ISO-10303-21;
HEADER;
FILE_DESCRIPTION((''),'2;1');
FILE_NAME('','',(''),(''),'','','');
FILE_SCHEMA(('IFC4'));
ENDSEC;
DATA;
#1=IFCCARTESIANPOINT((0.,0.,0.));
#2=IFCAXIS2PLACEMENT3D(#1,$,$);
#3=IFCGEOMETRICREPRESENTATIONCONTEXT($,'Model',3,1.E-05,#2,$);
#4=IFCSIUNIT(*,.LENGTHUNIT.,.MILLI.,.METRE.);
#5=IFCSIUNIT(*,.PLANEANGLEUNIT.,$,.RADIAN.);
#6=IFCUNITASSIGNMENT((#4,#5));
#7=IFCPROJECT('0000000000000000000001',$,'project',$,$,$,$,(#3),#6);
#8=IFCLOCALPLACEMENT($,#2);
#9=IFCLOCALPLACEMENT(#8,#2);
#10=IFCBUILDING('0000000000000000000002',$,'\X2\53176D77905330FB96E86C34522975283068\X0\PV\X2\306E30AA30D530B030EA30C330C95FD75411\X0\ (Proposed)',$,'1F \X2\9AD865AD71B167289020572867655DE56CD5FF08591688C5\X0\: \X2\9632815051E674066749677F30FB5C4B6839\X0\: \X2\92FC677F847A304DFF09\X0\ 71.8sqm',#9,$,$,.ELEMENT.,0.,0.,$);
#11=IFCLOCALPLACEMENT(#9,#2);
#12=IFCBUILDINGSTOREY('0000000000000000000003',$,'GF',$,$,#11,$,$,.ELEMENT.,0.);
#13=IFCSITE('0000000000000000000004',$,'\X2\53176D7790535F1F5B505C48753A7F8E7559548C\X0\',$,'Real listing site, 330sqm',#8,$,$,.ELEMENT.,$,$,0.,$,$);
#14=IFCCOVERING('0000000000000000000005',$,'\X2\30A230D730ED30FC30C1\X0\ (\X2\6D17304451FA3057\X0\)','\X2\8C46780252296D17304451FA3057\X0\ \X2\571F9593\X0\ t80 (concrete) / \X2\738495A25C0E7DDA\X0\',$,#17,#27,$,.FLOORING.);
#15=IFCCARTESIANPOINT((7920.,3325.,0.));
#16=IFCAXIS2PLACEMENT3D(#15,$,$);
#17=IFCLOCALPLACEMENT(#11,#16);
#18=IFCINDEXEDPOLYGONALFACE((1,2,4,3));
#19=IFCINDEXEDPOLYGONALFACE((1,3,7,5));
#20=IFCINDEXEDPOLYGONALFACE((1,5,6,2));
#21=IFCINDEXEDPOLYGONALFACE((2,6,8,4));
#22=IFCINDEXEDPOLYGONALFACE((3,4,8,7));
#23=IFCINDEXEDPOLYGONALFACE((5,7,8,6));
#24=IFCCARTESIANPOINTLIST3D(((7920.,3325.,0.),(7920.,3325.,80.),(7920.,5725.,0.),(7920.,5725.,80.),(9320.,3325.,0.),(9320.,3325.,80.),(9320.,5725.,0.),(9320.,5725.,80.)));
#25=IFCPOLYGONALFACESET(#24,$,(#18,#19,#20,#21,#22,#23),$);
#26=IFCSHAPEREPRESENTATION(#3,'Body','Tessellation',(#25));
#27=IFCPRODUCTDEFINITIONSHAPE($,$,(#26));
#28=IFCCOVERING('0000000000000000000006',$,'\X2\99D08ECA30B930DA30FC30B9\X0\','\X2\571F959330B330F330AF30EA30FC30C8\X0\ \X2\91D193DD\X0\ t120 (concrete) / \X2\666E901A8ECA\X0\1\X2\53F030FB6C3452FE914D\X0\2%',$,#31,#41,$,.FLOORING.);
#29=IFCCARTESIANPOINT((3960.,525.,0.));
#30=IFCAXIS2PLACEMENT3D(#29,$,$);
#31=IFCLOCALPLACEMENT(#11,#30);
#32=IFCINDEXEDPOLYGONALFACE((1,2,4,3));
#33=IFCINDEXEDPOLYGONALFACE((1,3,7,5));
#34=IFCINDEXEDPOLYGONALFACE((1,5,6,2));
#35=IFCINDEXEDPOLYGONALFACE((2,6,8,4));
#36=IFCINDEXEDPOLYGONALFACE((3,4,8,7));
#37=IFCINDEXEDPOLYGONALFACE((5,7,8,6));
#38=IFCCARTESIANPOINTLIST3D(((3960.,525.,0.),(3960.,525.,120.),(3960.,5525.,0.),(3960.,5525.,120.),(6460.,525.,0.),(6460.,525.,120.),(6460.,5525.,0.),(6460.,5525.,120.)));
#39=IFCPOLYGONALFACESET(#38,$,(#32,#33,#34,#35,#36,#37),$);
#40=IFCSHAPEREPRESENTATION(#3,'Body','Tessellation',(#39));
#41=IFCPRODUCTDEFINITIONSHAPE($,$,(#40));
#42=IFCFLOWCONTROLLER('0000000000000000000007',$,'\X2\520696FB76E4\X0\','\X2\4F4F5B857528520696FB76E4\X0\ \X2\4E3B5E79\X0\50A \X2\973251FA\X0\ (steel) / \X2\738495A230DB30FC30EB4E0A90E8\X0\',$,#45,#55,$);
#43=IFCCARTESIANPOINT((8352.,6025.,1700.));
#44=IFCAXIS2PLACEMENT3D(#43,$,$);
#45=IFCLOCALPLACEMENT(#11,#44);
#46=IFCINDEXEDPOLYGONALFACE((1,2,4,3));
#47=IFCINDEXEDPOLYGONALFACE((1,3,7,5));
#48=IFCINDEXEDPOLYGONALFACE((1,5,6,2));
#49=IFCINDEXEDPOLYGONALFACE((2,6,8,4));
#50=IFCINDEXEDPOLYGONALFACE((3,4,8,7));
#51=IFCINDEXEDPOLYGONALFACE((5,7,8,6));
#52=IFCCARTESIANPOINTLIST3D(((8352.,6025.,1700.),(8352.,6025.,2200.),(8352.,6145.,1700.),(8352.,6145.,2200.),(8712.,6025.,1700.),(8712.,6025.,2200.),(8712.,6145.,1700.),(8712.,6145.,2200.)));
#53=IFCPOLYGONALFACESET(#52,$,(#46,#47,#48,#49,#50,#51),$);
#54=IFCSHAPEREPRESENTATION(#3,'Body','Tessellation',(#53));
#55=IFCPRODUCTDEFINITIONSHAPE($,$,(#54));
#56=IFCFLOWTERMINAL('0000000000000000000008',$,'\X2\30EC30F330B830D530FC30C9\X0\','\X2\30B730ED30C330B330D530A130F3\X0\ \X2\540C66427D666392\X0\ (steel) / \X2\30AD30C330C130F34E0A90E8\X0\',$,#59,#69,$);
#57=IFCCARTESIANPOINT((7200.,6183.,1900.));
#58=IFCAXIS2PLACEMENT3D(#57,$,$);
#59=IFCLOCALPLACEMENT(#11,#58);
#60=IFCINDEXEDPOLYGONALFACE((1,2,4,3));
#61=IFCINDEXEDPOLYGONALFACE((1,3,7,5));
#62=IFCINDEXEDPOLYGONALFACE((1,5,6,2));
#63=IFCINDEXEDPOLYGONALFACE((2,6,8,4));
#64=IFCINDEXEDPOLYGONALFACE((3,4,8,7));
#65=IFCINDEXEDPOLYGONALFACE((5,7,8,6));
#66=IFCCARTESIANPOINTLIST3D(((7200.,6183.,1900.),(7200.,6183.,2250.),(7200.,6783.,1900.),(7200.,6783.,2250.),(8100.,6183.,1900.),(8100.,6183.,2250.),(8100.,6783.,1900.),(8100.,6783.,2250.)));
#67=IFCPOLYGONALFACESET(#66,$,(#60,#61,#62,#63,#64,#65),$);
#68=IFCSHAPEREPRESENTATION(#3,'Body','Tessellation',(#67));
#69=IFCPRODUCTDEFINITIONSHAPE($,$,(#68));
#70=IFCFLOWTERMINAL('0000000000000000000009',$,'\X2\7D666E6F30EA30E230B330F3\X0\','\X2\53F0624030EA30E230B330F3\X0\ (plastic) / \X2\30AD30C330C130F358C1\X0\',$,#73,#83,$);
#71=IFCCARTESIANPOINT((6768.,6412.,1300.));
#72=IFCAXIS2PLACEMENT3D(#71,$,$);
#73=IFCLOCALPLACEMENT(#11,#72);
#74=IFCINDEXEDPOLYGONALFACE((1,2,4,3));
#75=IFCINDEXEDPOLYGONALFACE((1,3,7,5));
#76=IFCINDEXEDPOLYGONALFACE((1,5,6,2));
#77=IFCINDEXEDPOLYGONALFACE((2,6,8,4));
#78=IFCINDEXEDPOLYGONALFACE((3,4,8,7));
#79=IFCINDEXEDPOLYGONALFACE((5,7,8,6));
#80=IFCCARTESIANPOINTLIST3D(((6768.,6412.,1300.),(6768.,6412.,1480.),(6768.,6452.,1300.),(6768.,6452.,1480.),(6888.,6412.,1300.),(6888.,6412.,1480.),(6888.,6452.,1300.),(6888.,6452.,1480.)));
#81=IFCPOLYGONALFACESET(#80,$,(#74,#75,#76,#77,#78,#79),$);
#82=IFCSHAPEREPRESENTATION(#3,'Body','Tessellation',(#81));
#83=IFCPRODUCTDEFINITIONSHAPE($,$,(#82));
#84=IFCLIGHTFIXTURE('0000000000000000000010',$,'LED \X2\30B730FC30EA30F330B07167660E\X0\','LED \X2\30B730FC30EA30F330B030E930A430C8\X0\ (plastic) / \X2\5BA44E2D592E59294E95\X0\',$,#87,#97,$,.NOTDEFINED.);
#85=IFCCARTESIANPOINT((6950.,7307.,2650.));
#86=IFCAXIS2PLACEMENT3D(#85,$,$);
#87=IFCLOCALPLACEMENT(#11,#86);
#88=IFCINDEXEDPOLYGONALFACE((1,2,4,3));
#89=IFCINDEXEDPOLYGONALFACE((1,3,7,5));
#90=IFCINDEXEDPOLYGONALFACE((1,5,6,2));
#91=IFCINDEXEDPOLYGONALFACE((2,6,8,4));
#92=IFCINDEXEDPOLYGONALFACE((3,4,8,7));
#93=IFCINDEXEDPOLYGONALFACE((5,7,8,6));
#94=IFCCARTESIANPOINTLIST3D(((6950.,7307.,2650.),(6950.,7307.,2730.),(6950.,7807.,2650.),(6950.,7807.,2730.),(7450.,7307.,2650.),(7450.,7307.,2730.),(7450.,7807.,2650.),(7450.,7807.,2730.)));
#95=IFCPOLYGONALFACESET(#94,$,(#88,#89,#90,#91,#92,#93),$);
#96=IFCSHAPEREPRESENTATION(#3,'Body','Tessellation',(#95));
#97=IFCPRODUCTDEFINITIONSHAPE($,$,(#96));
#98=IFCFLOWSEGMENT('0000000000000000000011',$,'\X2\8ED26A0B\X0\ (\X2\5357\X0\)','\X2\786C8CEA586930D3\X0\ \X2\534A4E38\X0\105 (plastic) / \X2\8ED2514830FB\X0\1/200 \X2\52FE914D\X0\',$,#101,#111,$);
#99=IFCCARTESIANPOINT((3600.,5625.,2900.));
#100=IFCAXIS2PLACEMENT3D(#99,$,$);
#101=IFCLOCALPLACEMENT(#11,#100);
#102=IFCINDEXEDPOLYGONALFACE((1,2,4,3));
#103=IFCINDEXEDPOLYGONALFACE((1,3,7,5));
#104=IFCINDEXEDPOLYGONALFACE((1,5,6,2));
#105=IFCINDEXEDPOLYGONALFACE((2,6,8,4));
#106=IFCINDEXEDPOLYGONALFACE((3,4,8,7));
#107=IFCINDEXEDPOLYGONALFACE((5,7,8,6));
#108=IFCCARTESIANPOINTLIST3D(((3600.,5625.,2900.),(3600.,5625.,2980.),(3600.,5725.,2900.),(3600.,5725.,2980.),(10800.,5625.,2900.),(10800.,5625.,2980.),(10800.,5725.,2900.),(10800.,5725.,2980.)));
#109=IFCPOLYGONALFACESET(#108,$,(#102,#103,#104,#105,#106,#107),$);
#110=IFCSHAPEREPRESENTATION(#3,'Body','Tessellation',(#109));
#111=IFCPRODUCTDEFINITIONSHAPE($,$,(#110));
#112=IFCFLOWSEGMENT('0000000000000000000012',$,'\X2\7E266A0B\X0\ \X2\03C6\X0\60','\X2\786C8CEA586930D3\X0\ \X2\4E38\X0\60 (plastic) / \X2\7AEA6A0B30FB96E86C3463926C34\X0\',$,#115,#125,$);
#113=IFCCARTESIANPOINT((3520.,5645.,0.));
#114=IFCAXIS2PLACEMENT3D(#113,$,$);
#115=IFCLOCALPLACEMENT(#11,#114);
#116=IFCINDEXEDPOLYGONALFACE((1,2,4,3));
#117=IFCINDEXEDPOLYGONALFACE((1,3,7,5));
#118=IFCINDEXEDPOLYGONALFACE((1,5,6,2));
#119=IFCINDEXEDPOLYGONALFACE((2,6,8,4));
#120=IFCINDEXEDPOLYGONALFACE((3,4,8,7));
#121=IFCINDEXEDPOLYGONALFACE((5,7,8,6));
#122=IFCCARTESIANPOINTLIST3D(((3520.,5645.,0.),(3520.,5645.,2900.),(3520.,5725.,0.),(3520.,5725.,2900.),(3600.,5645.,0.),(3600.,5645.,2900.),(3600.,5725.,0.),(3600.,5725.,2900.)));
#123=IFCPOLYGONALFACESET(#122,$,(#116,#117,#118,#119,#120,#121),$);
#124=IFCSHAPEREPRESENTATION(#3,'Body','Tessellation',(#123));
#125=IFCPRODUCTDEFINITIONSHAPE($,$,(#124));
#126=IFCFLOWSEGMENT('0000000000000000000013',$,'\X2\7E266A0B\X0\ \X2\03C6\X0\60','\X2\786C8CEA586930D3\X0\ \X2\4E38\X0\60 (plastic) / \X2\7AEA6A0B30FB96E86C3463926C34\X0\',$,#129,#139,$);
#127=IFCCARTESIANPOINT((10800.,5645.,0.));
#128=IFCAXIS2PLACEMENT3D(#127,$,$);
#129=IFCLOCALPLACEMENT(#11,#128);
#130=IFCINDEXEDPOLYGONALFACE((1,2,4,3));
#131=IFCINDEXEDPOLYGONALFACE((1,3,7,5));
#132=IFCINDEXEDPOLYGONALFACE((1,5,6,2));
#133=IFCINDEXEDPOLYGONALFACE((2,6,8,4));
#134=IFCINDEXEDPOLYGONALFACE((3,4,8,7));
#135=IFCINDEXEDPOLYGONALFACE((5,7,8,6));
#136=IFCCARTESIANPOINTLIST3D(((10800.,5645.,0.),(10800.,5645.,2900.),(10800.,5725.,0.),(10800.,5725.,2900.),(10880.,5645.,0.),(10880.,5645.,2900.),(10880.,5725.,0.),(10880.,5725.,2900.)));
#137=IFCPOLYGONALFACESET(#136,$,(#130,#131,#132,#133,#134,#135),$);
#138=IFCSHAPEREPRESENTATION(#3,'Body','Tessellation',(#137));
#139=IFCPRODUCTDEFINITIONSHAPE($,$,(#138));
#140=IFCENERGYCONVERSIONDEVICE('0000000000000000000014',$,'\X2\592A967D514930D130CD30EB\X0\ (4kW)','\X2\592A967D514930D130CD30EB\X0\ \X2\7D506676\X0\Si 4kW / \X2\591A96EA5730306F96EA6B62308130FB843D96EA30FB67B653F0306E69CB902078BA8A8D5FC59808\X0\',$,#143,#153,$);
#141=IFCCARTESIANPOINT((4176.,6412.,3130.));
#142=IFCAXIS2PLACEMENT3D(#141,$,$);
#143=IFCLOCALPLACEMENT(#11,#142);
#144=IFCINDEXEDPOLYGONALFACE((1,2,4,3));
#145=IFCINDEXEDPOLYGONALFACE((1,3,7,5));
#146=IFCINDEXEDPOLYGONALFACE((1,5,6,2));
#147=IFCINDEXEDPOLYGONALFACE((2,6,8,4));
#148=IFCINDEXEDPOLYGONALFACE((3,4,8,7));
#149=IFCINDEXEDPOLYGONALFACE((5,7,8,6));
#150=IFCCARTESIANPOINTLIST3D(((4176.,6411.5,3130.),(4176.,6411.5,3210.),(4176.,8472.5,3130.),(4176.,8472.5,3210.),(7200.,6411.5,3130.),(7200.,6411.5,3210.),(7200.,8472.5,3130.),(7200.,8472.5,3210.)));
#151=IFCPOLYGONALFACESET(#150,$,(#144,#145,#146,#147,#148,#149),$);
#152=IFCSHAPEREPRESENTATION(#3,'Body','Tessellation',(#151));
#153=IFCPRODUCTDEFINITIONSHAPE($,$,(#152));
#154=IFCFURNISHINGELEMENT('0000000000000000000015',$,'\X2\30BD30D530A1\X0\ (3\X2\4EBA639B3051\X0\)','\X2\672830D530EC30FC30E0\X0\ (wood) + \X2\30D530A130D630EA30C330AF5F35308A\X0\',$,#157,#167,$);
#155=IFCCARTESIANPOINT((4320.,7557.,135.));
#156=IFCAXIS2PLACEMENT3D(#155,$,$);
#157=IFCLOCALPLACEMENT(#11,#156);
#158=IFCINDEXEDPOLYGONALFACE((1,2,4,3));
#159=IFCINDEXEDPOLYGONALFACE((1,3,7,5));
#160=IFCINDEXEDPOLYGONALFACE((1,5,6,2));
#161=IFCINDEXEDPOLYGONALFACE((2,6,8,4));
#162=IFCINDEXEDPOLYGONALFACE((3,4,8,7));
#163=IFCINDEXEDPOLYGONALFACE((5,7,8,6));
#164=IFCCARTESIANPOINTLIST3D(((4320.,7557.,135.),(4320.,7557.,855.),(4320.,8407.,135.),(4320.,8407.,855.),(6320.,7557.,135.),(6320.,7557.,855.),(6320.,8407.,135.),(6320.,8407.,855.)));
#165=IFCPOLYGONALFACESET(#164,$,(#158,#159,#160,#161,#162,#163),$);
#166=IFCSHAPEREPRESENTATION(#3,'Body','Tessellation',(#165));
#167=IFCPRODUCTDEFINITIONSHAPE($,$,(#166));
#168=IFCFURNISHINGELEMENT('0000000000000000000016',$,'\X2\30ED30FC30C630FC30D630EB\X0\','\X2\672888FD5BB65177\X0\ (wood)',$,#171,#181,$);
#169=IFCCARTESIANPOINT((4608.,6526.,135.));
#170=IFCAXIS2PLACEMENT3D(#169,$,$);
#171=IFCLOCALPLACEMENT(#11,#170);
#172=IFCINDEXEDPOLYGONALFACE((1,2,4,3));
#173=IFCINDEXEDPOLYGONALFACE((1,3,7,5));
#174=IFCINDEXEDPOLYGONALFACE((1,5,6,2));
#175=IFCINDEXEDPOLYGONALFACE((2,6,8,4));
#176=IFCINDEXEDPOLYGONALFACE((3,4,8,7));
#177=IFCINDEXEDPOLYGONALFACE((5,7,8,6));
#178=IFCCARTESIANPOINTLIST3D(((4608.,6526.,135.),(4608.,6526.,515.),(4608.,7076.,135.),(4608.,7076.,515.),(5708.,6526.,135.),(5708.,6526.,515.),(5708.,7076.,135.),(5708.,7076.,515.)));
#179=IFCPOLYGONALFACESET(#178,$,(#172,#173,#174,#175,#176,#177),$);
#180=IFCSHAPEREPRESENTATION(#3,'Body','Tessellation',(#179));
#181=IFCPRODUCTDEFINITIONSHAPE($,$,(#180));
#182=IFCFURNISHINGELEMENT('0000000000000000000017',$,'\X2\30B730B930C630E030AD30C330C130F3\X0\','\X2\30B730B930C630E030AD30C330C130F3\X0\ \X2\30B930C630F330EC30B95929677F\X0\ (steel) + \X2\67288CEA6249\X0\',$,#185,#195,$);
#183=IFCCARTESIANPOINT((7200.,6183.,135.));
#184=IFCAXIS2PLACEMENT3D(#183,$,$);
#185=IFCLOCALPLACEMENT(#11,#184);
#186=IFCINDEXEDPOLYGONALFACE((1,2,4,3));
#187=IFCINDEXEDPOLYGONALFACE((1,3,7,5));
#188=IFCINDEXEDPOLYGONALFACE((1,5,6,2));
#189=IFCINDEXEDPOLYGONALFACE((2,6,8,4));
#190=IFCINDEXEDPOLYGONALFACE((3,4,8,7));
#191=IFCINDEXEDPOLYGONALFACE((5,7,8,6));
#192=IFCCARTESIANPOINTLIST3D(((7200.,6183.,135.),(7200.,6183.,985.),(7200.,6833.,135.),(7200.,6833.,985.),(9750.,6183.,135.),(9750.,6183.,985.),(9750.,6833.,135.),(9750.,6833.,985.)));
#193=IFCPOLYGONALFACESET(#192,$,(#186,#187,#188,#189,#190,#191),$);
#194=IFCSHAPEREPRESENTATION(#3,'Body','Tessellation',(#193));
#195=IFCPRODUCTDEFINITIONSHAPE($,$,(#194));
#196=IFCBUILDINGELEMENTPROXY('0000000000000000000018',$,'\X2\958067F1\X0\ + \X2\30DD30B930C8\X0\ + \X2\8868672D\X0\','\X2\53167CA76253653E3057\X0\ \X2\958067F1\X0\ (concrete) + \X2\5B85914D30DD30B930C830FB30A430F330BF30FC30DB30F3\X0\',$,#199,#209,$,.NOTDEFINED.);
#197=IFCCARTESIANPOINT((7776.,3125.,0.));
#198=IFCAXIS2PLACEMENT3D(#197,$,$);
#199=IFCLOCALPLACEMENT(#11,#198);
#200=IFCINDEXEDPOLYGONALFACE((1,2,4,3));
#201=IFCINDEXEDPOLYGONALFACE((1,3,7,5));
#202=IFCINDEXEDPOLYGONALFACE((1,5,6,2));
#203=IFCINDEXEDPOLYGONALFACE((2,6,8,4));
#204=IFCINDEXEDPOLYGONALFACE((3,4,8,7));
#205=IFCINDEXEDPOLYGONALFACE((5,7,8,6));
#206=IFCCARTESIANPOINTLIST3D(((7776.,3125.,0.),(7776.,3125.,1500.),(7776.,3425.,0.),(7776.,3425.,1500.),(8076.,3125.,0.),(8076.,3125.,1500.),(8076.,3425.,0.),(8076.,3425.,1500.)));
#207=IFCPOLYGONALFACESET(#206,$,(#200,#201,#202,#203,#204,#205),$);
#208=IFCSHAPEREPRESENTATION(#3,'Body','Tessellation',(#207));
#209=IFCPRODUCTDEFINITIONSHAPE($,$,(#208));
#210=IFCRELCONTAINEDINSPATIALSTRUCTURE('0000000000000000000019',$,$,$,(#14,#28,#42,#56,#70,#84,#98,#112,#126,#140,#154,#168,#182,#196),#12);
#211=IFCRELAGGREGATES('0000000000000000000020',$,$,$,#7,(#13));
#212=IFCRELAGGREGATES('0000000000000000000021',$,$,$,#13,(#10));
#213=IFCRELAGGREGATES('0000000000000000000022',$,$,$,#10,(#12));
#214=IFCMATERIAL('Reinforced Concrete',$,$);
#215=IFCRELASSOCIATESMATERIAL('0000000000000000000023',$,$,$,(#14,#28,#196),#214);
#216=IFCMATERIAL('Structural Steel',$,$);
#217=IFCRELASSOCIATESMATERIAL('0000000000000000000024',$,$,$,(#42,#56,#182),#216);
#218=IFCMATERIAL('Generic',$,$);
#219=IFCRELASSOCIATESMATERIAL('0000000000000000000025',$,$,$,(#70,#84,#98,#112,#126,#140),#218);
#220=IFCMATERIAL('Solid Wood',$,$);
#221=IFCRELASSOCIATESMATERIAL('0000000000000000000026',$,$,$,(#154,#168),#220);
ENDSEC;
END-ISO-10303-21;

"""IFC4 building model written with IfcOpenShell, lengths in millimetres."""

from ifc_helpers import new_model, si_unit, frame, frame_2d, origin, place, context, project, spatial, rectangle, extrude, material, element, save


model = new_model("IFC4")

# Units and contexts
model_context = context("Model", 3, precision=1e-05, world=origin())
ifc_project = project(units=[si_unit("LENGTHUNIT", "METRE", prefix="MILLI"), si_unit("PLANEANGLEUNIT", "RADIAN")], contexts=[model_context])

# Site, building, storey
site_placement = place(None, origin())
site = spatial("IfcSite", under=ifc_project, at=site_placement, Name="北海道弟子屈町美留和", ObjectType="Real listing site, 330sqm", CompositionType="ELEMENT", RefElevation=0.0)
building_placement = place(site_placement, origin())
building = spatial("IfcBuilding", under=site, at=building_placement, Name="北海道・雨水利用とPVのオフグリッド志向 (Proposed)", ObjectType="1F 高断熱木造在来工法（外装: 防腐処理杉板・屋根: 鋼板葺き） 71.8sqm", CompositionType="ELEMENT", ElevationOfRefHeight=0.0, ElevationOfTerrain=0.0)
storey_placement = place(building_placement, origin())
storey = spatial("IfcBuildingStorey", under=building, at=storey_placement, Name="GF", CompositionType="ELEMENT", Elevation=0.0)

# Shared definitions
ifc_material_1 = material(Name="Solid Wood")

# Shared definitions
ifc_material_2 = material(Name="Reinforced Concrete")

# Shared definitions
ifc_material_3 = material(Name="Structural Steel")

# Coverings
ifc_material_4 = material(Name="Generic")
covering_1_placement = place(storey_placement, frame((7920.0, 3325.0, 0.0)))
element("IfcCovering", 1, at=covering_1_placement, inside=storey, material=ifc_material_2, Name="アプローチ (洗い出し)", Description="豆砂利洗い出し 土間 t80 (concrete) / 玄関導線", PredefinedType="FLOORING", context=model_context, shape_type="SweptSolid", body=[
    extrude(rectangle(XDim=1400.0, YDim=2400.0, at=frame_2d((700.0, 1200.0))), frame((7920.0, 3325.0, 0.0)), (0.0, 0.0, 1.0), 80.0),
])
covering_2_placement = place(storey_placement, frame((3960.0, 525.0, 0.0)))
element("IfcCovering", 2, at=covering_2_placement, inside=storey, material=ifc_material_2, Name="駐車スペース", Description="土間コンクリート 金鏝 t120 (concrete) / 普通車1台・水勾配2%", PredefinedType="FLOORING", context=model_context, shape_type="SweptSolid", body=[
    extrude(rectangle(XDim=2500.0, YDim=5000.0, at=frame_2d((1250.0, 2500.0))), frame((3960.0, 525.0, 0.0)), (0.0, 0.0, 1.0), 120.0),
])

# Flow controller
flow_controller_placement = place(storey_placement, frame((8352.0, 6025.0, 1700.0)))
element("IfcFlowController", 3, at=flow_controller_placement, inside=storey, material=ifc_material_3, Name="分電盤", Description="住宅用分電盤 主幹50A 露出 (steel) / 玄関ホール上部", context=model_context, shape_type="SweptSolid", body=[
    extrude(rectangle(XDim=360.0, YDim=120.0, at=frame_2d((180.0, 60.0))), frame((8352.0, 6025.0, 1700.0)), (0.0, 0.0, 1.0), 500.0),
])

# Flow terminals
flow_terminal_1_placement = place(storey_placement, frame((7200.0, 6183.0, 1900.0)))
element("IfcFlowTerminal", 4, at=flow_terminal_1_placement, inside=storey, material=ifc_material_3, Name="レンジフード", Description="シロッコファン 同時給排 (steel) / キッチン上部", context=model_context, shape_type="SweptSolid", body=[
    extrude(rectangle(XDim=900.0, YDim=600.0, at=frame_2d((450.0, 300.0))), frame((7200.0, 6183.0, 1900.0)), (0.0, 0.0, 1.0), 350.0),
])
flow_terminal_2_placement = place(storey_placement, frame((6768.0, 6412.0, 1300.0)))
element("IfcFlowTerminal", 5, at=flow_terminal_2_placement, inside=storey, material=ifc_material_4, Name="給湯リモコン", Description="台所リモコン (plastic) / キッチン壁", context=model_context, shape_type="SweptSolid", body=[
    extrude(rectangle(XDim=120.0, YDim=40.0, at=frame_2d((60.0, 20.0))), frame((6768.0, 6412.0, 1300.0)), (0.0, 0.0, 1.0), 180.0),
])

# Light fixture
light_fixture_placement = place(storey_placement, frame((6950.0, 7307.0, 2650.0)))
element("IfcLightFixture", 6, at=light_fixture_placement, inside=storey, material=ifc_material_4, Name="LED シーリング照明", Description="LED シーリングライト (plastic) / 室中央天井", PredefinedType="NOTDEFINED", context=model_context, shape_type="SweptSolid", body=[
    extrude(rectangle(XDim=500.0, YDim=500.0, at=frame_2d((250.0, 250.0))), frame((6950.0, 7307.0, 2650.0)), (0.0, 0.0, 1.0), 80.0),
])

# Flow segments
flow_segment_1_placement = place(storey_placement, frame((3600.0, 5625.0, 2900.0)))
element("IfcFlowSegment", 7, at=flow_segment_1_placement, inside=storey, material=ifc_material_4, Name="軒樋 (南)", Description="硬質塩ビ 半丸105 (plastic) / 軒先・1/200 勾配", context=model_context, shape_type="SweptSolid", body=[
    extrude(rectangle(XDim=7200.0, YDim=100.0, at=frame_2d((3600.0, 50.0))), frame((3600.0, 5625.0, 2900.0)), (0.0, 0.0, 1.0), 80.0),
])
flow_segment_2_placement = place(storey_placement, frame((3520.0, 5645.0, 0.0)))
element("IfcFlowSegment", 8, at=flow_segment_2_placement, inside=storey, material=ifc_material_4, Name="縦樋 φ60", Description="硬質塩ビ 丸60 (plastic) / 竪樋・雨水排水", context=model_context, shape_type="SweptSolid", body=[
    extrude(rectangle(XDim=80.0, YDim=80.0, at=frame_2d((40.0, 40.0))), frame((3520.0, 5645.0, 0.0)), (0.0, 0.0, 1.0), 2900.0),
])
flow_segment_3_placement = place(storey_placement, frame((10800.0, 5645.0, 0.0)))
element("IfcFlowSegment", 9, at=flow_segment_3_placement, inside=storey, material=ifc_material_4, Name="縦樋 φ60", Description="硬質塩ビ 丸60 (plastic) / 竪樋・雨水排水", context=model_context, shape_type="SweptSolid", body=[
    extrude(rectangle(XDim=80.0, YDim=80.0, at=frame_2d((40.0, 40.0))), frame((10800.0, 5645.0, 0.0)), (0.0, 0.0, 1.0), 2900.0),
])

# Energy conversion device
energy_conversion_device_placement = place(storey_placement, frame((4176.0, 6412.0, 3130.0)))
element("IfcEnergyConversionDevice", 10, at=energy_conversion_device_placement, inside=storey, material=ifc_material_4, Name="太陽光パネル (4kW)", Description="太陽光パネル 結晶Si 4kW / 多雪地は雪止め・落雪・架台の構造確認必須", context=model_context, shape_type="SweptSolid", body=[
    extrude(rectangle(XDim=3024.0, YDim=2061.0, at=frame_2d((1512.0, 1030.0))), frame((4176.0, 6412.0, 3130.0)), (0.0, 0.0, 1.0), 80.0),
])

# Furnishing elements
furnishing_1_placement = place(storey_placement, frame((4320.0, 7557.0, 135.0)))
element("IfcFurnishingElement", 11, at=furnishing_1_placement, inside=storey, material=ifc_material_1, Name="ソファ (3人掛け)", Description="木フレーム (wood) + ファブリック張り", context=model_context, shape_type="SweptSolid", body=[
    extrude(rectangle(XDim=2000.0, YDim=850.0, at=frame_2d((1000.0, 425.0))), frame((4320.0, 7557.0, 135.0)), (0.0, 0.0, 1.0), 720.0),
])
furnishing_2_placement = place(storey_placement, frame((4608.0, 6526.0, 135.0)))
element("IfcFurnishingElement", 12, at=furnishing_2_placement, inside=storey, material=ifc_material_1, Name="ローテーブル", Description="木製家具 (wood)", context=model_context, shape_type="SweptSolid", body=[
    extrude(rectangle(XDim=1100.0, YDim=550.0, at=frame_2d((550.0, 275.0))), frame((4608.0, 6526.0, 135.0)), (0.0, 0.0, 1.0), 380.0),
])
furnishing_3_placement = place(storey_placement, frame((7200.0, 6183.0, 135.0)))
element("IfcFurnishingElement", 13, at=furnishing_3_placement, inside=storey, material=ifc_material_3, Name="システムキッチン", Description="システムキッチン ステンレス天板 (steel) + 木質扉", context=model_context, shape_type="SweptSolid", body=[
    extrude(rectangle(XDim=2550.0, YDim=650.0, at=frame_2d((1275.0, 325.0))), frame((7200.0, 6183.0, 135.0)), (0.0, 0.0, 1.0), 850.0),
])

# Building element proxy
proxy_placement = place(storey_placement, frame((7776.0, 3125.0, 0.0)))
element("IfcBuildingElementProxy", 14, at=proxy_placement, inside=storey, material=ifc_material_2, Name="門柱 + ポスト + 表札", Description="化粧打放し 門柱 (concrete) + 宅配ポスト・インターホン", PredefinedType="NOTDEFINED", context=model_context, shape_type="SweptSolid", body=[
    extrude(rectangle(XDim=300.0, YDim=300.0, at=frame_2d((150.0, 150.0))), frame((7776.0, 3125.0, 0.0)), (0.0, 0.0, 1.0), 1500.0),
])

save(model, "model.ifc")
